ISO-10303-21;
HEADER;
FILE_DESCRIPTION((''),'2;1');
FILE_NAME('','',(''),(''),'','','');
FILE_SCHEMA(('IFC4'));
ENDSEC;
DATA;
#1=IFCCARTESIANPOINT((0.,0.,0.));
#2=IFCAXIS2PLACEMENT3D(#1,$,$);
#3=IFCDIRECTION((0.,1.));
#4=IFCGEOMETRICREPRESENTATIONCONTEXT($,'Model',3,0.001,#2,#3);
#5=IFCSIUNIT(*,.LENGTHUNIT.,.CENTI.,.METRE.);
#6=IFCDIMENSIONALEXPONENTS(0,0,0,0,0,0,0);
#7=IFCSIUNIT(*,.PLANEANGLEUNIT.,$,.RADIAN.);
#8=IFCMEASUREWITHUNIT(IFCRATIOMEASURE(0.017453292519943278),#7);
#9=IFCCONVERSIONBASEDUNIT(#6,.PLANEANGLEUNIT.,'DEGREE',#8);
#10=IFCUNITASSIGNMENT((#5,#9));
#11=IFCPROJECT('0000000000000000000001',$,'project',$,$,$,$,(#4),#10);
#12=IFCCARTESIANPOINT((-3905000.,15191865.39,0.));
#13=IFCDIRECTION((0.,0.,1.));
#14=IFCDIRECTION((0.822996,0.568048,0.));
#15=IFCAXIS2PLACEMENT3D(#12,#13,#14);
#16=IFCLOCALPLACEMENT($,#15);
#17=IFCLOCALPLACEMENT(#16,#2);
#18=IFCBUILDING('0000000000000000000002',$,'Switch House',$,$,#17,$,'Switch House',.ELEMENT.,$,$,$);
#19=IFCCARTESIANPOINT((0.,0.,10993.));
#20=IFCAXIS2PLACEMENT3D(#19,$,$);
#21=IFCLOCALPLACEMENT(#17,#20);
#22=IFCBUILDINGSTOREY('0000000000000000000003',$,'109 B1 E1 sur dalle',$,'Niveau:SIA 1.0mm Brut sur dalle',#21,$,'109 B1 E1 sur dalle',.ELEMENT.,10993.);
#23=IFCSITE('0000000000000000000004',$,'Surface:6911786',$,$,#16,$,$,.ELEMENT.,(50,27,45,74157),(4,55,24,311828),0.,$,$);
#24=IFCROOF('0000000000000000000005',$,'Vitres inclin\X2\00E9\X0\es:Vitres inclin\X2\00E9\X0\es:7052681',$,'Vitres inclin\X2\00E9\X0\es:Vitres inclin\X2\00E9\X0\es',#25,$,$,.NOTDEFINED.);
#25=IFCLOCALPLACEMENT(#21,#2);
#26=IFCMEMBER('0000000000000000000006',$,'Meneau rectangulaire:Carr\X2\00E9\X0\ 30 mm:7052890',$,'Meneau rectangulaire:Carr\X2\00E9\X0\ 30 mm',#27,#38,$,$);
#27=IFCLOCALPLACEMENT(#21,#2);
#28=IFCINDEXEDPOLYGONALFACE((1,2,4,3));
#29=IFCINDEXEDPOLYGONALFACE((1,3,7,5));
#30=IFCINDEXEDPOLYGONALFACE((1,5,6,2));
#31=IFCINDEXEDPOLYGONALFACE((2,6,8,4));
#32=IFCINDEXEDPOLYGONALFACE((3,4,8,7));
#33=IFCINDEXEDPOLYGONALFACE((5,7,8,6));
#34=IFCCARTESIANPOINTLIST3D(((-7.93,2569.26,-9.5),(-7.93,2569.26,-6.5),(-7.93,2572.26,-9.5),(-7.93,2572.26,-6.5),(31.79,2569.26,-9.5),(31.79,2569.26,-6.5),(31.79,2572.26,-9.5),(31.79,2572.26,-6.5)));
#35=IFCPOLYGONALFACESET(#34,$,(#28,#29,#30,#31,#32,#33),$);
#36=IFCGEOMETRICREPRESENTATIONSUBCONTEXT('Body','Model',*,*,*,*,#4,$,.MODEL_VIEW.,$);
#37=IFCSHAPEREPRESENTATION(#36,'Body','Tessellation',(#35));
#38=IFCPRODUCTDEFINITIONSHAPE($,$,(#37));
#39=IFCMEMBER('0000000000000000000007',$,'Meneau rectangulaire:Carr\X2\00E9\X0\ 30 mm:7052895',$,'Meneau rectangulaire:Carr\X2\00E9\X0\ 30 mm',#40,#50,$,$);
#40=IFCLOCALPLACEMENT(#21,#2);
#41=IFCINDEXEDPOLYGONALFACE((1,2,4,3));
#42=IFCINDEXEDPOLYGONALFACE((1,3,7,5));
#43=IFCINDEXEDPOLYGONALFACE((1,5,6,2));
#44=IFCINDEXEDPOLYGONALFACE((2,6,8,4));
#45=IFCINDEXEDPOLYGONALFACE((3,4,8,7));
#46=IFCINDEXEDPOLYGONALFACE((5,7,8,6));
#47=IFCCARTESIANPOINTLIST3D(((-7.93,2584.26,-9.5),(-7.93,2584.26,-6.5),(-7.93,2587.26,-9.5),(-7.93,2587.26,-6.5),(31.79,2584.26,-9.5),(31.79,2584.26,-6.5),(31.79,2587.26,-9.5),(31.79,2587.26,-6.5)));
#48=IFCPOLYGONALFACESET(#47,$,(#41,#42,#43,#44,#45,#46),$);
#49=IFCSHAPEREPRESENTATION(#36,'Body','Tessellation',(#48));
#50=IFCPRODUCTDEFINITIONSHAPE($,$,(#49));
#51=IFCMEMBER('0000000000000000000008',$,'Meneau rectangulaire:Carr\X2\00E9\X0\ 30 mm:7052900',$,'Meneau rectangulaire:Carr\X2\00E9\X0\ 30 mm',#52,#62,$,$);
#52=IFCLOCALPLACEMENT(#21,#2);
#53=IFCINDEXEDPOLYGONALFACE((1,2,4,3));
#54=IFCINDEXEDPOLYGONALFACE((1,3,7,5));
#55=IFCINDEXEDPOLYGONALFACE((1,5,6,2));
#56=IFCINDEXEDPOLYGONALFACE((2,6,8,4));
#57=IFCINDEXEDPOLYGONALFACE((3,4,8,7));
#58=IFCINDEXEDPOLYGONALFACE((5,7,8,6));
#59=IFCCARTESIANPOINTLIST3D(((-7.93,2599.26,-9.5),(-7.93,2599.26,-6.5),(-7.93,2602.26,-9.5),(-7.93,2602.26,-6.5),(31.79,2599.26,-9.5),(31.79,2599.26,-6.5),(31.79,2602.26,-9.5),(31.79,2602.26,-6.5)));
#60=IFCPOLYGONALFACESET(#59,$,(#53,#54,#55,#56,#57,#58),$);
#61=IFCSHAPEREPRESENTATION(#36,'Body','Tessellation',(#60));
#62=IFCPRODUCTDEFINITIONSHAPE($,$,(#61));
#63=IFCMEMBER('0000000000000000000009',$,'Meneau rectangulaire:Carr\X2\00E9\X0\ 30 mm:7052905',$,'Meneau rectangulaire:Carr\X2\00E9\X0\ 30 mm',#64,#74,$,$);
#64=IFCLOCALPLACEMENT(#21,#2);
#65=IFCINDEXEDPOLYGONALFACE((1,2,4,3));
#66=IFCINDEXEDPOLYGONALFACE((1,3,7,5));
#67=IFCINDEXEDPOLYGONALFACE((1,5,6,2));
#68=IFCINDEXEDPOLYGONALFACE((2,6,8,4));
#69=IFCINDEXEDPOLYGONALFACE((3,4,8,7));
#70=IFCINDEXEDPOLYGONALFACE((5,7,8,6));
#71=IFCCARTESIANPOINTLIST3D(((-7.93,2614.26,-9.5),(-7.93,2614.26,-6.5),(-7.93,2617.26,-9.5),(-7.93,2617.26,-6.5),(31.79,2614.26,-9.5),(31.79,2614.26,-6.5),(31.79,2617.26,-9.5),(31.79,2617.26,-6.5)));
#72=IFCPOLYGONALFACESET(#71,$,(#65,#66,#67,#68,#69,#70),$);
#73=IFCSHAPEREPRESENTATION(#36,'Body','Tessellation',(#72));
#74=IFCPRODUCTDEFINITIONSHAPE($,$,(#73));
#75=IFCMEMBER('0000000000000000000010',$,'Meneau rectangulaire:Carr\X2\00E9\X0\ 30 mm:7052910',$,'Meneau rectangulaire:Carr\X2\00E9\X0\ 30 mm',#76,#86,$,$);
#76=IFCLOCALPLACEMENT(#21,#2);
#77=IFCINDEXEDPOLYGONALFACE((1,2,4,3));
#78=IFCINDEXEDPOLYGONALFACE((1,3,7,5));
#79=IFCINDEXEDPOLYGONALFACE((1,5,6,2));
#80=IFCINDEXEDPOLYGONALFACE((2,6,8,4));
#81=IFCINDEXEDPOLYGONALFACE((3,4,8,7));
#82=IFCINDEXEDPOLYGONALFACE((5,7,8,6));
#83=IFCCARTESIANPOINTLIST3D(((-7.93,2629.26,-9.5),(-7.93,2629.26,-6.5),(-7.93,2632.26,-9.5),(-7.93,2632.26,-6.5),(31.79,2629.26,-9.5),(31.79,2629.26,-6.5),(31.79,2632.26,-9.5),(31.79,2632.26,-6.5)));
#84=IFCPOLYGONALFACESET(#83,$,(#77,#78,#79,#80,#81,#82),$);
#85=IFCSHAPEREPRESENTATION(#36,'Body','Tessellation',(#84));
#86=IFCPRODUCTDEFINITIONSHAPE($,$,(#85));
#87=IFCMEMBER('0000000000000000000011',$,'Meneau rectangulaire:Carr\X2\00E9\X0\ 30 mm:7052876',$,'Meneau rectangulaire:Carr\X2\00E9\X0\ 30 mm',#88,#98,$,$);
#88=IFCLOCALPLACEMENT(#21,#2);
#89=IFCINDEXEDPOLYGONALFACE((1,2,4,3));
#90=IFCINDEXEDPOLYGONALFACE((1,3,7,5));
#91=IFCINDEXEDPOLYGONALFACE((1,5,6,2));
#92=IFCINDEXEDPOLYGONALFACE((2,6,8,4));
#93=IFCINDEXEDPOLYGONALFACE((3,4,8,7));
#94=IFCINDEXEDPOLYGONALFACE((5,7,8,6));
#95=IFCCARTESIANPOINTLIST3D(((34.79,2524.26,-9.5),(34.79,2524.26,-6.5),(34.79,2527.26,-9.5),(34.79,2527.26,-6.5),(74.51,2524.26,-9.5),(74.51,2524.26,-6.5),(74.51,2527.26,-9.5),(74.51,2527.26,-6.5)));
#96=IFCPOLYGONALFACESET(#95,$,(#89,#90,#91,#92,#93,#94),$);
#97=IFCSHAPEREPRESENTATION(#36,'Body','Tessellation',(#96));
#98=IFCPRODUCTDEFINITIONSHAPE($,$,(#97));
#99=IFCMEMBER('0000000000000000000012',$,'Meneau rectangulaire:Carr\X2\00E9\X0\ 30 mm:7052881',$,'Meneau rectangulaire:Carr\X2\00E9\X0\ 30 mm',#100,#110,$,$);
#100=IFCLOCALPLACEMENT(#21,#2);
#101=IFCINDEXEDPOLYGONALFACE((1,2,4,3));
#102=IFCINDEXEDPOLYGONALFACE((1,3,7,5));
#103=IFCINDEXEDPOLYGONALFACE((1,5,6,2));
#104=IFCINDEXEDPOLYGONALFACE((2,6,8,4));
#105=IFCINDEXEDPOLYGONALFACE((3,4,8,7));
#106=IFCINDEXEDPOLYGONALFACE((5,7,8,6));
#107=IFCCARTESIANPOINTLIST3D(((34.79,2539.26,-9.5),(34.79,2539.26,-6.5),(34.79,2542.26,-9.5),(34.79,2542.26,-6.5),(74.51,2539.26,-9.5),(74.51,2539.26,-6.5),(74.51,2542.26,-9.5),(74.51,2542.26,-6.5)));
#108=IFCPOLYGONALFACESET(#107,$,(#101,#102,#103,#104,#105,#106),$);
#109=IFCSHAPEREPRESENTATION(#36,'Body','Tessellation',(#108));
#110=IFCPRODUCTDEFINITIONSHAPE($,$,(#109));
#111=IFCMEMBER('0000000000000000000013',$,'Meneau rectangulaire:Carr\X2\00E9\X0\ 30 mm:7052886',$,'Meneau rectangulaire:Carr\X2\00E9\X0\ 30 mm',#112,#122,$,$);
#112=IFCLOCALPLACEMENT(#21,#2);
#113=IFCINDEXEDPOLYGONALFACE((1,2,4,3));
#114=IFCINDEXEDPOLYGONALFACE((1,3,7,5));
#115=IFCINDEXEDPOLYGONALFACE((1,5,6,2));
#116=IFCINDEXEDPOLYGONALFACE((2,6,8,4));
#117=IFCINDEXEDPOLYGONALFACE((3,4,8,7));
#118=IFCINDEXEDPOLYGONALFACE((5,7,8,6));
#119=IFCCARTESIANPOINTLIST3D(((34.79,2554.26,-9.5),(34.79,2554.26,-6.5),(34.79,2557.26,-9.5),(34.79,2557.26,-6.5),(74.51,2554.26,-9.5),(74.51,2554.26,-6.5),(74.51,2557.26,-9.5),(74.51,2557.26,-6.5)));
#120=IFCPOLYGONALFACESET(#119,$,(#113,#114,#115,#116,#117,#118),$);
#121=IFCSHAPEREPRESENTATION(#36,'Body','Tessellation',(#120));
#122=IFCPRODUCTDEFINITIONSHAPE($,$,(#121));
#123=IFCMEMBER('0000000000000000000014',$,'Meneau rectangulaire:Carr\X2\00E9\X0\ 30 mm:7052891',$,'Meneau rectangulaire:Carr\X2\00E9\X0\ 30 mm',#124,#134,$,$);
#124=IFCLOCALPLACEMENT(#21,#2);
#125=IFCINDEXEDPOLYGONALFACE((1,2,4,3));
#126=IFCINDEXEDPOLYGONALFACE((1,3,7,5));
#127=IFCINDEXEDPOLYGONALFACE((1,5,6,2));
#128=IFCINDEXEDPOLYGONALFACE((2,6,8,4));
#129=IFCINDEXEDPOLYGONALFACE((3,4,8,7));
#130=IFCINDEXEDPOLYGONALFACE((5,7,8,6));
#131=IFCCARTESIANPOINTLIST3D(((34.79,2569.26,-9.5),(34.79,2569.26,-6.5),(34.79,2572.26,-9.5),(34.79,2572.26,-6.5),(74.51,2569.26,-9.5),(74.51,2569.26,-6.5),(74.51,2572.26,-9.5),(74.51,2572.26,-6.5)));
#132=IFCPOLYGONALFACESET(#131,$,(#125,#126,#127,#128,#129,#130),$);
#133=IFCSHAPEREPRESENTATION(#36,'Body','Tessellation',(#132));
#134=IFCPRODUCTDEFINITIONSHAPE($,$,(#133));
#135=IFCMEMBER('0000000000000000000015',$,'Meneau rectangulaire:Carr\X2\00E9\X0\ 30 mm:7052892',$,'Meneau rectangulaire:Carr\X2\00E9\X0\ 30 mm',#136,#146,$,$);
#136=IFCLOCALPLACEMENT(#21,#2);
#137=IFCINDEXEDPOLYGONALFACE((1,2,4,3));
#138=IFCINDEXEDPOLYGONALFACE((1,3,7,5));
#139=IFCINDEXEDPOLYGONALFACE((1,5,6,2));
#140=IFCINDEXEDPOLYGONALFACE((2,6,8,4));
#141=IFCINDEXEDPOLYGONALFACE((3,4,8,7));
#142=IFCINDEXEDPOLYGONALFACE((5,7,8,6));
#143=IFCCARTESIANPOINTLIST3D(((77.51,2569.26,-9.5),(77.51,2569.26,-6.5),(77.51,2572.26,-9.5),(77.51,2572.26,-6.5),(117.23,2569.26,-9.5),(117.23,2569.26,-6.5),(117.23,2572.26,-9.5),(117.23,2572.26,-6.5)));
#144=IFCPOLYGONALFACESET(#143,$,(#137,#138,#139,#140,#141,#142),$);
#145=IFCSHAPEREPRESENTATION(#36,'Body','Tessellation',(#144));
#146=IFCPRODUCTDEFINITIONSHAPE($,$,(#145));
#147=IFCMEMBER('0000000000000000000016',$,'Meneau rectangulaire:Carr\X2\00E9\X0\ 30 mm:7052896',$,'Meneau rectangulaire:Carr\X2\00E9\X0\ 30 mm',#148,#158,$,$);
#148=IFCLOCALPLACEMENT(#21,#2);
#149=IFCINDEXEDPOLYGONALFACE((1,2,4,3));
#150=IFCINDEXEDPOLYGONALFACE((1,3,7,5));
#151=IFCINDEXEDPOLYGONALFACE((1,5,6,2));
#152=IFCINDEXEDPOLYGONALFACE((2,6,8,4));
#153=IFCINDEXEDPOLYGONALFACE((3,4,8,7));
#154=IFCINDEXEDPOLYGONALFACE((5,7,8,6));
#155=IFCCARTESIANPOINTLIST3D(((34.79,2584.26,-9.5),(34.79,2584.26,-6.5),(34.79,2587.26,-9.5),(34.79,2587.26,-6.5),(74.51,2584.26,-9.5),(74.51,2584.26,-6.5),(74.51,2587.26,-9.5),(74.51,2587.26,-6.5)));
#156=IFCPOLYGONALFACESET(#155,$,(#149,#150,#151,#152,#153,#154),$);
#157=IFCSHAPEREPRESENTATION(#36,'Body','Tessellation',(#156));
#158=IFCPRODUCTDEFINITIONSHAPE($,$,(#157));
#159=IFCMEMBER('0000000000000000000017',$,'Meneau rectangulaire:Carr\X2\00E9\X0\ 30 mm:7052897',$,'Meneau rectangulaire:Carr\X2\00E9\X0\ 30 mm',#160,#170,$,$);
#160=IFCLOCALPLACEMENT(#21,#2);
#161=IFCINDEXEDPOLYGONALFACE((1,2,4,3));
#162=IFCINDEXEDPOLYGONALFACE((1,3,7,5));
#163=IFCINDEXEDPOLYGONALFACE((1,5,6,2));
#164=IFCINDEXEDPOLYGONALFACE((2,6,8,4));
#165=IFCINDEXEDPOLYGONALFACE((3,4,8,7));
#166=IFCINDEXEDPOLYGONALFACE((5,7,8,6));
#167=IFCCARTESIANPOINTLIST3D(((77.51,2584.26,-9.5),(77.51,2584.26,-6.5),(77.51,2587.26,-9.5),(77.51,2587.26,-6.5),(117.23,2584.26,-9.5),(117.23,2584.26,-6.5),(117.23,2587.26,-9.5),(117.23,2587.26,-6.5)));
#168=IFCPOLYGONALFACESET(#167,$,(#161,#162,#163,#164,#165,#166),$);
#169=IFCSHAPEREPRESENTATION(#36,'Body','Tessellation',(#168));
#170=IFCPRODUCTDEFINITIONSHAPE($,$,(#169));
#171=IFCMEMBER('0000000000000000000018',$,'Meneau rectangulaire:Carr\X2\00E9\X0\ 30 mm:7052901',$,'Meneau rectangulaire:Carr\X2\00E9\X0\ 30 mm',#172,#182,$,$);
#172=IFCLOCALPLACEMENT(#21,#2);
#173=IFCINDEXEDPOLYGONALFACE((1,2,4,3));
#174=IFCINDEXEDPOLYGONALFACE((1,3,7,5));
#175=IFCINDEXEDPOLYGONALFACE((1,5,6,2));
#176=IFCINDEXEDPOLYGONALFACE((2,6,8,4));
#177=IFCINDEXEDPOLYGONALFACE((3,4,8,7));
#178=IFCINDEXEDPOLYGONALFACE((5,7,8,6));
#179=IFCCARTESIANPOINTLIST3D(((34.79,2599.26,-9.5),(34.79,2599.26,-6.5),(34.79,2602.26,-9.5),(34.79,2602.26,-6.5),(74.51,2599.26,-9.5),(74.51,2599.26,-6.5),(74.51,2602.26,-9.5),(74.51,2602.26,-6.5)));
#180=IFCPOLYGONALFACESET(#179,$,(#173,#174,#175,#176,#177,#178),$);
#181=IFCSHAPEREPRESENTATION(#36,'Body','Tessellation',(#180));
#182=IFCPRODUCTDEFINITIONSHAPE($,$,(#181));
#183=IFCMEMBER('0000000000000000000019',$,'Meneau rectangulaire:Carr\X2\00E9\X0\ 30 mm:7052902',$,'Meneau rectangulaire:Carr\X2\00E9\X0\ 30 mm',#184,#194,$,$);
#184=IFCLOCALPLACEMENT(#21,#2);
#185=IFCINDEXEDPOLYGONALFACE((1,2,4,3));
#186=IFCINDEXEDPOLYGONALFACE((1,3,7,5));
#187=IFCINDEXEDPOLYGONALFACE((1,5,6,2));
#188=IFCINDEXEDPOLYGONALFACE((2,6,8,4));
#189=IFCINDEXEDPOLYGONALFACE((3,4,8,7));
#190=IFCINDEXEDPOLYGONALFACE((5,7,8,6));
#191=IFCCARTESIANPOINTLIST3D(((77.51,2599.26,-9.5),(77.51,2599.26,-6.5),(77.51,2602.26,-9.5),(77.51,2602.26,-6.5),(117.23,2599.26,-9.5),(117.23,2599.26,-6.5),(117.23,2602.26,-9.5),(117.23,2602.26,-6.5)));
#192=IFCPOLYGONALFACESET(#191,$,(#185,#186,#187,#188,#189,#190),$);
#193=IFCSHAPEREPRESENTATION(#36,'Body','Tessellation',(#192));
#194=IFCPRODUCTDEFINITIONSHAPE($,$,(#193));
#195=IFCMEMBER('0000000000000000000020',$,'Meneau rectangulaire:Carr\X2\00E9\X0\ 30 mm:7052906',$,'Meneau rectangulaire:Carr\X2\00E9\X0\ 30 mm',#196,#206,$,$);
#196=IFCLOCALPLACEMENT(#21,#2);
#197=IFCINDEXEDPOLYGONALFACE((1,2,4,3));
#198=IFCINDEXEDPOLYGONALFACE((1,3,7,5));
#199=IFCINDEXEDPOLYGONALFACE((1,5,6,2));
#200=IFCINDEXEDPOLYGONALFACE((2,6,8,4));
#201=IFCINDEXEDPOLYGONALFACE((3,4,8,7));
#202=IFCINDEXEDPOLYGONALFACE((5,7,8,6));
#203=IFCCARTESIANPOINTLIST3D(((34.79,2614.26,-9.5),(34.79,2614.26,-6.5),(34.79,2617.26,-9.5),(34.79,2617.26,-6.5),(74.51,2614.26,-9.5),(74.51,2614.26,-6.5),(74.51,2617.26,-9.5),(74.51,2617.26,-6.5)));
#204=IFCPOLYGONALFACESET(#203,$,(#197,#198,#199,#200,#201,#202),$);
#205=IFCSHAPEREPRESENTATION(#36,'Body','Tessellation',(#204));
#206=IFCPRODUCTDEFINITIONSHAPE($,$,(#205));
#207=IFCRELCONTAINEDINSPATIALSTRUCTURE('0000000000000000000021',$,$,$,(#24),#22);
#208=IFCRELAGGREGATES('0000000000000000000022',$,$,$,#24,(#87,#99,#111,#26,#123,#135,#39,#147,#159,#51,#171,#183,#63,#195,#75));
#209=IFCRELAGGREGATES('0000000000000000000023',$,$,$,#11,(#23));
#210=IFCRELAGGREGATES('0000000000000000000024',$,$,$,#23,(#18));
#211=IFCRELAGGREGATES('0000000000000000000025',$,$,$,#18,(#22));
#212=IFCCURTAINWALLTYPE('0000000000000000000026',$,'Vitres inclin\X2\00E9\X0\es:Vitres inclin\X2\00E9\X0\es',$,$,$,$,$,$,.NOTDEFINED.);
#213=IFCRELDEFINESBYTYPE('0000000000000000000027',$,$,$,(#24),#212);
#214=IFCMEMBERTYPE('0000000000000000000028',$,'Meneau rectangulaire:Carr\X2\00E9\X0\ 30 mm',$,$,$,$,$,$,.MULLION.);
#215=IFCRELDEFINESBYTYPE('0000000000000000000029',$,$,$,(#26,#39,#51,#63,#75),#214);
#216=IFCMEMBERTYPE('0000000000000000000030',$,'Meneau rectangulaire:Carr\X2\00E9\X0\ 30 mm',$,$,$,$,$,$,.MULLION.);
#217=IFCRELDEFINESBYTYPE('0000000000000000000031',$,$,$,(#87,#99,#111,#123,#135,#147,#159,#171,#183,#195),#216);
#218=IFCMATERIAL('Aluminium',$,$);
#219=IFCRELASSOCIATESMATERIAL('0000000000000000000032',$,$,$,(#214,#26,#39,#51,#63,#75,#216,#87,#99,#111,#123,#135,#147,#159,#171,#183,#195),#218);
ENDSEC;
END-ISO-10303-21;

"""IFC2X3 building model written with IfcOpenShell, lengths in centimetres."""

from ifc_helpers import new_model, entity, si_unit, converted_unit, direction, frame, origin, origin_2d_with_axis, place, context, subcontext, project, spatial, rectangle, extrude, source, transform, mapped, material, type_object, type_shapes, element, aggregate, save


model = new_model("IFC2X3")

# Units and contexts
model_context = context("Model", 3, precision=0.001, world=origin(), true_north=direction((0.0, 1.0)))
body_context = subcontext(model_context, "Body", "Model", "MODEL_VIEW")
ifc_project = project(units=[si_unit("LENGTHUNIT", "METRE", prefix="CENTI"), converted_unit("PLANEANGLEUNIT", "DEGREE", entity("IfcRatioMeasure", 0.017453292519943278), si_unit("PLANEANGLEUNIT", "RADIAN"), dimensions=[0, 0, 0, 0, 0, 0, 0])], contexts=[model_context])

# Site, building, storey
site_placement = place(None, frame((-3905000.0, 15191865.39, 0.0), z_axis=(0.0, 0.0, 1.0), x_axis=(0.822996, 0.568048, 0.0)))
site = spatial("IfcSite", under=ifc_project, at=site_placement, Name="Surface:6911786", CompositionType="ELEMENT", RefLatitude=(50, 27, 45, 74157), RefLongitude=(4, 55, 24, 311828), RefElevation=0.0)
building_placement = place(site_placement, origin())
building = spatial("IfcBuilding", under=site, at=building_placement, Name="Switch House", LongName="Switch House", CompositionType="ELEMENT")
storey_placement = place(building_placement, frame((0.0, 0.0, 10993.0)))
storey = spatial("IfcBuildingStorey", under=building, at=storey_placement, Name="109 B1 E1 sur dalle", ObjectType="Niveau:SIA 1.0mm Brut sur dalle", LongName="109 B1 E1 sur dalle", CompositionType="ELEMENT", Elevation=10993.0)

# Roof, members
curtain_wall_type = type_object("IfcCurtainWallType", Name="Vitres inclinées:Vitres inclinées", PredefinedType="NOTDEFINED")
roof_placement = place(storey_placement, frame((0.0, 0.0, -10993.0)))
roof = element("IfcRoof", 1, at=roof_placement, inside=storey, type_object=curtain_wall_type, Name="Vitres inclinées:Vitres inclinées:7052681", ObjectType="Vitres inclinées:Vitres inclinées", ShapeType="NOTDEFINED")
ifc_material = material(Name="Aluminium")
member_type_1 = type_object("IfcMemberType", Name="Meneau rectangulaire:Carré 30 mm", PredefinedType="MULLION", material=ifc_material)
shared_shape_1 = source(origin(), body_context, "Body", "SweptSolid", [
    extrude(rectangle(XDim=3.0, YDim=3.0, at=origin_2d_with_axis()), frame((0.0, 0.0, -39.72), z_axis=(0.0, 0.0, 1.0), x_axis=(0.0, -1.0, 0.0)), (0.0, 0.0, 1.0), 39.72),
])
type_shapes(member_type_1, [shared_shape_1])
member_1_placement = place(roof_placement, frame((-7.93, 2570.76, 10985.0), z_axis=(-1.0, 0.0, 0.0), x_axis=(0.0, 1.0, 0.0)))
member_1 = element("IfcMember", 2, at=member_1_placement, type_object=member_type_1, material=ifc_material, Name="Meneau rectangulaire:Carré 30 mm:7052890", ObjectType="Meneau rectangulaire:Carré 30 mm", context=body_context, shape_type="MappedRepresentation", body=[
    mapped(shared_shape_1, transform((0.0, 0.0, 0.0), scale=1.0)),
])
member_2_placement = place(roof_placement, frame((-7.93, 2585.76, 10985.0), z_axis=(-1.0, 0.0, 0.0), x_axis=(0.0, 1.0, 0.0)))
member_2 = element("IfcMember", 3, at=member_2_placement, type_object=member_type_1, material=ifc_material, Name="Meneau rectangulaire:Carré 30 mm:7052895", ObjectType="Meneau rectangulaire:Carré 30 mm", context=body_context, shape_type="MappedRepresentation", body=[
    mapped(shared_shape_1, transform((0.0, 0.0, 0.0), scale=1.0)),
])
member_3_placement = place(roof_placement, frame((-7.93, 2600.76, 10985.0), z_axis=(-1.0, 0.0, 0.0), x_axis=(0.0, 1.0, 0.0)))
member_3 = element("IfcMember", 4, at=member_3_placement, type_object=member_type_1, material=ifc_material, Name="Meneau rectangulaire:Carré 30 mm:7052900", ObjectType="Meneau rectangulaire:Carré 30 mm", context=body_context, shape_type="MappedRepresentation", body=[
    mapped(shared_shape_1, transform((0.0, 0.0, 0.0), scale=1.0)),
])
member_4_placement = place(roof_placement, frame((-7.93, 2615.76, 10985.0), z_axis=(-1.0, 0.0, 0.0), x_axis=(0.0, 1.0, 0.0)))
member_4 = element("IfcMember", 5, at=member_4_placement, type_object=member_type_1, material=ifc_material, Name="Meneau rectangulaire:Carré 30 mm:7052905", ObjectType="Meneau rectangulaire:Carré 30 mm", context=body_context, shape_type="MappedRepresentation", body=[
    mapped(shared_shape_1, transform((0.0, 0.0, 0.0), scale=1.0)),
])
member_5_placement = place(roof_placement, frame((-7.93, 2630.76, 10985.0), z_axis=(-1.0, 0.0, 0.0), x_axis=(0.0, 1.0, 0.0)))
member_5 = element("IfcMember", 6, at=member_5_placement, type_object=member_type_1, material=ifc_material, Name="Meneau rectangulaire:Carré 30 mm:7052910", ObjectType="Meneau rectangulaire:Carré 30 mm", context=body_context, shape_type="MappedRepresentation", body=[
    mapped(shared_shape_1, transform((0.0, 0.0, 0.0), scale=1.0)),
])
member_type_2 = type_object("IfcMemberType", Name="Meneau rectangulaire:Carré 30 mm", PredefinedType="MULLION", material=ifc_material)
shared_shape_2 = source(origin(), body_context, "Body", "SweptSolid", [
    extrude(rectangle(XDim=3.0, YDim=3.0, at=origin_2d_with_axis()), frame((0.0, 0.0, -39.72), z_axis=(0.0, 0.0, 1.0), x_axis=(0.0, -1.0, 0.0)), (0.0, 0.0, 1.0), 39.72),
])
type_shapes(member_type_2, [shared_shape_2])
member_6_placement = place(roof_placement, frame((34.79, 2525.76, 10985.0), z_axis=(-1.0, 0.0, 0.0), x_axis=(0.0, 1.0, 0.0)))
member_6 = element("IfcMember", 7, at=member_6_placement, type_object=member_type_2, material=ifc_material, Name="Meneau rectangulaire:Carré 30 mm:7052876", ObjectType="Meneau rectangulaire:Carré 30 mm", context=body_context, shape_type="MappedRepresentation", body=[
    mapped(shared_shape_2, transform((0.0, 0.0, 0.0), scale=1.0)),
])
member_7_placement = place(roof_placement, frame((34.79, 2540.76, 10985.0), z_axis=(-1.0, 0.0, 0.0), x_axis=(0.0, 1.0, 0.0)))
member_7 = element("IfcMember", 8, at=member_7_placement, type_object=member_type_2, material=ifc_material, Name="Meneau rectangulaire:Carré 30 mm:7052881", ObjectType="Meneau rectangulaire:Carré 30 mm", context=body_context, shape_type="MappedRepresentation", body=[
    mapped(shared_shape_2, transform((0.0, 0.0, 0.0), scale=1.0)),
])
member_8_placement = place(roof_placement, frame((34.79, 2555.76, 10985.0), z_axis=(-1.0, 0.0, 0.0), x_axis=(0.0, 1.0, 0.0)))
member_8 = element("IfcMember", 9, at=member_8_placement, type_object=member_type_2, material=ifc_material, Name="Meneau rectangulaire:Carré 30 mm:7052886", ObjectType="Meneau rectangulaire:Carré 30 mm", context=body_context, shape_type="MappedRepresentation", body=[
    mapped(shared_shape_2, transform((0.0, 0.0, 0.0), scale=1.0)),
])
member_9_placement = place(roof_placement, frame((34.79, 2570.76, 10985.0), z_axis=(-1.0, 0.0, 0.0), x_axis=(0.0, 1.0, 0.0)))
member_9 = element("IfcMember", 10, at=member_9_placement, type_object=member_type_2, material=ifc_material, Name="Meneau rectangulaire:Carré 30 mm:7052891", ObjectType="Meneau rectangulaire:Carré 30 mm", context=body_context, shape_type="MappedRepresentation", body=[
    mapped(shared_shape_2, transform((0.0, 0.0, 0.0), scale=1.0)),
])
member_10_placement = place(roof_placement, frame((77.51, 2570.76, 10985.0), z_axis=(-1.0, 0.0, 0.0), x_axis=(0.0, 1.0, 0.0)))
member_10 = element("IfcMember", 11, at=member_10_placement, type_object=member_type_2, material=ifc_material, Name="Meneau rectangulaire:Carré 30 mm:7052892", ObjectType="Meneau rectangulaire:Carré 30 mm", context=body_context, shape_type="MappedRepresentation", body=[
    mapped(shared_shape_2, transform((0.0, 0.0, 0.0), scale=1.0)),
])
member_11_placement = place(roof_placement, frame((34.79, 2585.76, 10985.0), z_axis=(-1.0, 0.0, 0.0), x_axis=(0.0, 1.0, 0.0)))
member_11 = element("IfcMember", 12, at=member_11_placement, type_object=member_type_2, material=ifc_material, Name="Meneau rectangulaire:Carré 30 mm:7052896", ObjectType="Meneau rectangulaire:Carré 30 mm", context=body_context, shape_type="MappedRepresentation", body=[
    mapped(shared_shape_2, transform((0.0, 0.0, 0.0), scale=1.0)),
])
member_12_placement = place(roof_placement, frame((77.51, 2585.76, 10985.0), z_axis=(-1.0, 0.0, 0.0), x_axis=(0.0, 1.0, 0.0)))
member_12 = element("IfcMember", 13, at=member_12_placement, type_object=member_type_2, material=ifc_material, Name="Meneau rectangulaire:Carré 30 mm:7052897", ObjectType="Meneau rectangulaire:Carré 30 mm", context=body_context, shape_type="MappedRepresentation", body=[
    mapped(shared_shape_2, transform((0.0, 0.0, 0.0), scale=1.0)),
])
member_13_placement = place(roof_placement, frame((34.79, 2600.76, 10985.0), z_axis=(-1.0, 0.0, 0.0), x_axis=(0.0, 1.0, 0.0)))
member_13 = element("IfcMember", 14, at=member_13_placement, type_object=member_type_2, material=ifc_material, Name="Meneau rectangulaire:Carré 30 mm:7052901", ObjectType="Meneau rectangulaire:Carré 30 mm", context=body_context, shape_type="MappedRepresentation", body=[
    mapped(shared_shape_2, transform((0.0, 0.0, 0.0), scale=1.0)),
])
member_14_placement = place(roof_placement, frame((77.51, 2600.76, 10985.0), z_axis=(-1.0, 0.0, 0.0), x_axis=(0.0, 1.0, 0.0)))
member_14 = element("IfcMember", 15, at=member_14_placement, type_object=member_type_2, material=ifc_material, Name="Meneau rectangulaire:Carré 30 mm:7052902", ObjectType="Meneau rectangulaire:Carré 30 mm", context=body_context, shape_type="MappedRepresentation", body=[
    mapped(shared_shape_2, transform((0.0, 0.0, 0.0), scale=1.0)),
])
member_15_placement = place(roof_placement, frame((34.79, 2615.76, 10985.0), z_axis=(-1.0, 0.0, 0.0), x_axis=(0.0, 1.0, 0.0)))
member_15 = element("IfcMember", 16, at=member_15_placement, type_object=member_type_2, material=ifc_material, Name="Meneau rectangulaire:Carré 30 mm:7052906", ObjectType="Meneau rectangulaire:Carré 30 mm", context=body_context, shape_type="MappedRepresentation", body=[
    mapped(shared_shape_2, transform((0.0, 0.0, 0.0), scale=1.0)),
])
aggregate(roof, [member_6, member_7, member_8, member_1, member_9, member_10, member_2, member_11, member_12, member_3, member_13, member_14, member_4, member_15, member_5])

save(model, "model.ifc")
